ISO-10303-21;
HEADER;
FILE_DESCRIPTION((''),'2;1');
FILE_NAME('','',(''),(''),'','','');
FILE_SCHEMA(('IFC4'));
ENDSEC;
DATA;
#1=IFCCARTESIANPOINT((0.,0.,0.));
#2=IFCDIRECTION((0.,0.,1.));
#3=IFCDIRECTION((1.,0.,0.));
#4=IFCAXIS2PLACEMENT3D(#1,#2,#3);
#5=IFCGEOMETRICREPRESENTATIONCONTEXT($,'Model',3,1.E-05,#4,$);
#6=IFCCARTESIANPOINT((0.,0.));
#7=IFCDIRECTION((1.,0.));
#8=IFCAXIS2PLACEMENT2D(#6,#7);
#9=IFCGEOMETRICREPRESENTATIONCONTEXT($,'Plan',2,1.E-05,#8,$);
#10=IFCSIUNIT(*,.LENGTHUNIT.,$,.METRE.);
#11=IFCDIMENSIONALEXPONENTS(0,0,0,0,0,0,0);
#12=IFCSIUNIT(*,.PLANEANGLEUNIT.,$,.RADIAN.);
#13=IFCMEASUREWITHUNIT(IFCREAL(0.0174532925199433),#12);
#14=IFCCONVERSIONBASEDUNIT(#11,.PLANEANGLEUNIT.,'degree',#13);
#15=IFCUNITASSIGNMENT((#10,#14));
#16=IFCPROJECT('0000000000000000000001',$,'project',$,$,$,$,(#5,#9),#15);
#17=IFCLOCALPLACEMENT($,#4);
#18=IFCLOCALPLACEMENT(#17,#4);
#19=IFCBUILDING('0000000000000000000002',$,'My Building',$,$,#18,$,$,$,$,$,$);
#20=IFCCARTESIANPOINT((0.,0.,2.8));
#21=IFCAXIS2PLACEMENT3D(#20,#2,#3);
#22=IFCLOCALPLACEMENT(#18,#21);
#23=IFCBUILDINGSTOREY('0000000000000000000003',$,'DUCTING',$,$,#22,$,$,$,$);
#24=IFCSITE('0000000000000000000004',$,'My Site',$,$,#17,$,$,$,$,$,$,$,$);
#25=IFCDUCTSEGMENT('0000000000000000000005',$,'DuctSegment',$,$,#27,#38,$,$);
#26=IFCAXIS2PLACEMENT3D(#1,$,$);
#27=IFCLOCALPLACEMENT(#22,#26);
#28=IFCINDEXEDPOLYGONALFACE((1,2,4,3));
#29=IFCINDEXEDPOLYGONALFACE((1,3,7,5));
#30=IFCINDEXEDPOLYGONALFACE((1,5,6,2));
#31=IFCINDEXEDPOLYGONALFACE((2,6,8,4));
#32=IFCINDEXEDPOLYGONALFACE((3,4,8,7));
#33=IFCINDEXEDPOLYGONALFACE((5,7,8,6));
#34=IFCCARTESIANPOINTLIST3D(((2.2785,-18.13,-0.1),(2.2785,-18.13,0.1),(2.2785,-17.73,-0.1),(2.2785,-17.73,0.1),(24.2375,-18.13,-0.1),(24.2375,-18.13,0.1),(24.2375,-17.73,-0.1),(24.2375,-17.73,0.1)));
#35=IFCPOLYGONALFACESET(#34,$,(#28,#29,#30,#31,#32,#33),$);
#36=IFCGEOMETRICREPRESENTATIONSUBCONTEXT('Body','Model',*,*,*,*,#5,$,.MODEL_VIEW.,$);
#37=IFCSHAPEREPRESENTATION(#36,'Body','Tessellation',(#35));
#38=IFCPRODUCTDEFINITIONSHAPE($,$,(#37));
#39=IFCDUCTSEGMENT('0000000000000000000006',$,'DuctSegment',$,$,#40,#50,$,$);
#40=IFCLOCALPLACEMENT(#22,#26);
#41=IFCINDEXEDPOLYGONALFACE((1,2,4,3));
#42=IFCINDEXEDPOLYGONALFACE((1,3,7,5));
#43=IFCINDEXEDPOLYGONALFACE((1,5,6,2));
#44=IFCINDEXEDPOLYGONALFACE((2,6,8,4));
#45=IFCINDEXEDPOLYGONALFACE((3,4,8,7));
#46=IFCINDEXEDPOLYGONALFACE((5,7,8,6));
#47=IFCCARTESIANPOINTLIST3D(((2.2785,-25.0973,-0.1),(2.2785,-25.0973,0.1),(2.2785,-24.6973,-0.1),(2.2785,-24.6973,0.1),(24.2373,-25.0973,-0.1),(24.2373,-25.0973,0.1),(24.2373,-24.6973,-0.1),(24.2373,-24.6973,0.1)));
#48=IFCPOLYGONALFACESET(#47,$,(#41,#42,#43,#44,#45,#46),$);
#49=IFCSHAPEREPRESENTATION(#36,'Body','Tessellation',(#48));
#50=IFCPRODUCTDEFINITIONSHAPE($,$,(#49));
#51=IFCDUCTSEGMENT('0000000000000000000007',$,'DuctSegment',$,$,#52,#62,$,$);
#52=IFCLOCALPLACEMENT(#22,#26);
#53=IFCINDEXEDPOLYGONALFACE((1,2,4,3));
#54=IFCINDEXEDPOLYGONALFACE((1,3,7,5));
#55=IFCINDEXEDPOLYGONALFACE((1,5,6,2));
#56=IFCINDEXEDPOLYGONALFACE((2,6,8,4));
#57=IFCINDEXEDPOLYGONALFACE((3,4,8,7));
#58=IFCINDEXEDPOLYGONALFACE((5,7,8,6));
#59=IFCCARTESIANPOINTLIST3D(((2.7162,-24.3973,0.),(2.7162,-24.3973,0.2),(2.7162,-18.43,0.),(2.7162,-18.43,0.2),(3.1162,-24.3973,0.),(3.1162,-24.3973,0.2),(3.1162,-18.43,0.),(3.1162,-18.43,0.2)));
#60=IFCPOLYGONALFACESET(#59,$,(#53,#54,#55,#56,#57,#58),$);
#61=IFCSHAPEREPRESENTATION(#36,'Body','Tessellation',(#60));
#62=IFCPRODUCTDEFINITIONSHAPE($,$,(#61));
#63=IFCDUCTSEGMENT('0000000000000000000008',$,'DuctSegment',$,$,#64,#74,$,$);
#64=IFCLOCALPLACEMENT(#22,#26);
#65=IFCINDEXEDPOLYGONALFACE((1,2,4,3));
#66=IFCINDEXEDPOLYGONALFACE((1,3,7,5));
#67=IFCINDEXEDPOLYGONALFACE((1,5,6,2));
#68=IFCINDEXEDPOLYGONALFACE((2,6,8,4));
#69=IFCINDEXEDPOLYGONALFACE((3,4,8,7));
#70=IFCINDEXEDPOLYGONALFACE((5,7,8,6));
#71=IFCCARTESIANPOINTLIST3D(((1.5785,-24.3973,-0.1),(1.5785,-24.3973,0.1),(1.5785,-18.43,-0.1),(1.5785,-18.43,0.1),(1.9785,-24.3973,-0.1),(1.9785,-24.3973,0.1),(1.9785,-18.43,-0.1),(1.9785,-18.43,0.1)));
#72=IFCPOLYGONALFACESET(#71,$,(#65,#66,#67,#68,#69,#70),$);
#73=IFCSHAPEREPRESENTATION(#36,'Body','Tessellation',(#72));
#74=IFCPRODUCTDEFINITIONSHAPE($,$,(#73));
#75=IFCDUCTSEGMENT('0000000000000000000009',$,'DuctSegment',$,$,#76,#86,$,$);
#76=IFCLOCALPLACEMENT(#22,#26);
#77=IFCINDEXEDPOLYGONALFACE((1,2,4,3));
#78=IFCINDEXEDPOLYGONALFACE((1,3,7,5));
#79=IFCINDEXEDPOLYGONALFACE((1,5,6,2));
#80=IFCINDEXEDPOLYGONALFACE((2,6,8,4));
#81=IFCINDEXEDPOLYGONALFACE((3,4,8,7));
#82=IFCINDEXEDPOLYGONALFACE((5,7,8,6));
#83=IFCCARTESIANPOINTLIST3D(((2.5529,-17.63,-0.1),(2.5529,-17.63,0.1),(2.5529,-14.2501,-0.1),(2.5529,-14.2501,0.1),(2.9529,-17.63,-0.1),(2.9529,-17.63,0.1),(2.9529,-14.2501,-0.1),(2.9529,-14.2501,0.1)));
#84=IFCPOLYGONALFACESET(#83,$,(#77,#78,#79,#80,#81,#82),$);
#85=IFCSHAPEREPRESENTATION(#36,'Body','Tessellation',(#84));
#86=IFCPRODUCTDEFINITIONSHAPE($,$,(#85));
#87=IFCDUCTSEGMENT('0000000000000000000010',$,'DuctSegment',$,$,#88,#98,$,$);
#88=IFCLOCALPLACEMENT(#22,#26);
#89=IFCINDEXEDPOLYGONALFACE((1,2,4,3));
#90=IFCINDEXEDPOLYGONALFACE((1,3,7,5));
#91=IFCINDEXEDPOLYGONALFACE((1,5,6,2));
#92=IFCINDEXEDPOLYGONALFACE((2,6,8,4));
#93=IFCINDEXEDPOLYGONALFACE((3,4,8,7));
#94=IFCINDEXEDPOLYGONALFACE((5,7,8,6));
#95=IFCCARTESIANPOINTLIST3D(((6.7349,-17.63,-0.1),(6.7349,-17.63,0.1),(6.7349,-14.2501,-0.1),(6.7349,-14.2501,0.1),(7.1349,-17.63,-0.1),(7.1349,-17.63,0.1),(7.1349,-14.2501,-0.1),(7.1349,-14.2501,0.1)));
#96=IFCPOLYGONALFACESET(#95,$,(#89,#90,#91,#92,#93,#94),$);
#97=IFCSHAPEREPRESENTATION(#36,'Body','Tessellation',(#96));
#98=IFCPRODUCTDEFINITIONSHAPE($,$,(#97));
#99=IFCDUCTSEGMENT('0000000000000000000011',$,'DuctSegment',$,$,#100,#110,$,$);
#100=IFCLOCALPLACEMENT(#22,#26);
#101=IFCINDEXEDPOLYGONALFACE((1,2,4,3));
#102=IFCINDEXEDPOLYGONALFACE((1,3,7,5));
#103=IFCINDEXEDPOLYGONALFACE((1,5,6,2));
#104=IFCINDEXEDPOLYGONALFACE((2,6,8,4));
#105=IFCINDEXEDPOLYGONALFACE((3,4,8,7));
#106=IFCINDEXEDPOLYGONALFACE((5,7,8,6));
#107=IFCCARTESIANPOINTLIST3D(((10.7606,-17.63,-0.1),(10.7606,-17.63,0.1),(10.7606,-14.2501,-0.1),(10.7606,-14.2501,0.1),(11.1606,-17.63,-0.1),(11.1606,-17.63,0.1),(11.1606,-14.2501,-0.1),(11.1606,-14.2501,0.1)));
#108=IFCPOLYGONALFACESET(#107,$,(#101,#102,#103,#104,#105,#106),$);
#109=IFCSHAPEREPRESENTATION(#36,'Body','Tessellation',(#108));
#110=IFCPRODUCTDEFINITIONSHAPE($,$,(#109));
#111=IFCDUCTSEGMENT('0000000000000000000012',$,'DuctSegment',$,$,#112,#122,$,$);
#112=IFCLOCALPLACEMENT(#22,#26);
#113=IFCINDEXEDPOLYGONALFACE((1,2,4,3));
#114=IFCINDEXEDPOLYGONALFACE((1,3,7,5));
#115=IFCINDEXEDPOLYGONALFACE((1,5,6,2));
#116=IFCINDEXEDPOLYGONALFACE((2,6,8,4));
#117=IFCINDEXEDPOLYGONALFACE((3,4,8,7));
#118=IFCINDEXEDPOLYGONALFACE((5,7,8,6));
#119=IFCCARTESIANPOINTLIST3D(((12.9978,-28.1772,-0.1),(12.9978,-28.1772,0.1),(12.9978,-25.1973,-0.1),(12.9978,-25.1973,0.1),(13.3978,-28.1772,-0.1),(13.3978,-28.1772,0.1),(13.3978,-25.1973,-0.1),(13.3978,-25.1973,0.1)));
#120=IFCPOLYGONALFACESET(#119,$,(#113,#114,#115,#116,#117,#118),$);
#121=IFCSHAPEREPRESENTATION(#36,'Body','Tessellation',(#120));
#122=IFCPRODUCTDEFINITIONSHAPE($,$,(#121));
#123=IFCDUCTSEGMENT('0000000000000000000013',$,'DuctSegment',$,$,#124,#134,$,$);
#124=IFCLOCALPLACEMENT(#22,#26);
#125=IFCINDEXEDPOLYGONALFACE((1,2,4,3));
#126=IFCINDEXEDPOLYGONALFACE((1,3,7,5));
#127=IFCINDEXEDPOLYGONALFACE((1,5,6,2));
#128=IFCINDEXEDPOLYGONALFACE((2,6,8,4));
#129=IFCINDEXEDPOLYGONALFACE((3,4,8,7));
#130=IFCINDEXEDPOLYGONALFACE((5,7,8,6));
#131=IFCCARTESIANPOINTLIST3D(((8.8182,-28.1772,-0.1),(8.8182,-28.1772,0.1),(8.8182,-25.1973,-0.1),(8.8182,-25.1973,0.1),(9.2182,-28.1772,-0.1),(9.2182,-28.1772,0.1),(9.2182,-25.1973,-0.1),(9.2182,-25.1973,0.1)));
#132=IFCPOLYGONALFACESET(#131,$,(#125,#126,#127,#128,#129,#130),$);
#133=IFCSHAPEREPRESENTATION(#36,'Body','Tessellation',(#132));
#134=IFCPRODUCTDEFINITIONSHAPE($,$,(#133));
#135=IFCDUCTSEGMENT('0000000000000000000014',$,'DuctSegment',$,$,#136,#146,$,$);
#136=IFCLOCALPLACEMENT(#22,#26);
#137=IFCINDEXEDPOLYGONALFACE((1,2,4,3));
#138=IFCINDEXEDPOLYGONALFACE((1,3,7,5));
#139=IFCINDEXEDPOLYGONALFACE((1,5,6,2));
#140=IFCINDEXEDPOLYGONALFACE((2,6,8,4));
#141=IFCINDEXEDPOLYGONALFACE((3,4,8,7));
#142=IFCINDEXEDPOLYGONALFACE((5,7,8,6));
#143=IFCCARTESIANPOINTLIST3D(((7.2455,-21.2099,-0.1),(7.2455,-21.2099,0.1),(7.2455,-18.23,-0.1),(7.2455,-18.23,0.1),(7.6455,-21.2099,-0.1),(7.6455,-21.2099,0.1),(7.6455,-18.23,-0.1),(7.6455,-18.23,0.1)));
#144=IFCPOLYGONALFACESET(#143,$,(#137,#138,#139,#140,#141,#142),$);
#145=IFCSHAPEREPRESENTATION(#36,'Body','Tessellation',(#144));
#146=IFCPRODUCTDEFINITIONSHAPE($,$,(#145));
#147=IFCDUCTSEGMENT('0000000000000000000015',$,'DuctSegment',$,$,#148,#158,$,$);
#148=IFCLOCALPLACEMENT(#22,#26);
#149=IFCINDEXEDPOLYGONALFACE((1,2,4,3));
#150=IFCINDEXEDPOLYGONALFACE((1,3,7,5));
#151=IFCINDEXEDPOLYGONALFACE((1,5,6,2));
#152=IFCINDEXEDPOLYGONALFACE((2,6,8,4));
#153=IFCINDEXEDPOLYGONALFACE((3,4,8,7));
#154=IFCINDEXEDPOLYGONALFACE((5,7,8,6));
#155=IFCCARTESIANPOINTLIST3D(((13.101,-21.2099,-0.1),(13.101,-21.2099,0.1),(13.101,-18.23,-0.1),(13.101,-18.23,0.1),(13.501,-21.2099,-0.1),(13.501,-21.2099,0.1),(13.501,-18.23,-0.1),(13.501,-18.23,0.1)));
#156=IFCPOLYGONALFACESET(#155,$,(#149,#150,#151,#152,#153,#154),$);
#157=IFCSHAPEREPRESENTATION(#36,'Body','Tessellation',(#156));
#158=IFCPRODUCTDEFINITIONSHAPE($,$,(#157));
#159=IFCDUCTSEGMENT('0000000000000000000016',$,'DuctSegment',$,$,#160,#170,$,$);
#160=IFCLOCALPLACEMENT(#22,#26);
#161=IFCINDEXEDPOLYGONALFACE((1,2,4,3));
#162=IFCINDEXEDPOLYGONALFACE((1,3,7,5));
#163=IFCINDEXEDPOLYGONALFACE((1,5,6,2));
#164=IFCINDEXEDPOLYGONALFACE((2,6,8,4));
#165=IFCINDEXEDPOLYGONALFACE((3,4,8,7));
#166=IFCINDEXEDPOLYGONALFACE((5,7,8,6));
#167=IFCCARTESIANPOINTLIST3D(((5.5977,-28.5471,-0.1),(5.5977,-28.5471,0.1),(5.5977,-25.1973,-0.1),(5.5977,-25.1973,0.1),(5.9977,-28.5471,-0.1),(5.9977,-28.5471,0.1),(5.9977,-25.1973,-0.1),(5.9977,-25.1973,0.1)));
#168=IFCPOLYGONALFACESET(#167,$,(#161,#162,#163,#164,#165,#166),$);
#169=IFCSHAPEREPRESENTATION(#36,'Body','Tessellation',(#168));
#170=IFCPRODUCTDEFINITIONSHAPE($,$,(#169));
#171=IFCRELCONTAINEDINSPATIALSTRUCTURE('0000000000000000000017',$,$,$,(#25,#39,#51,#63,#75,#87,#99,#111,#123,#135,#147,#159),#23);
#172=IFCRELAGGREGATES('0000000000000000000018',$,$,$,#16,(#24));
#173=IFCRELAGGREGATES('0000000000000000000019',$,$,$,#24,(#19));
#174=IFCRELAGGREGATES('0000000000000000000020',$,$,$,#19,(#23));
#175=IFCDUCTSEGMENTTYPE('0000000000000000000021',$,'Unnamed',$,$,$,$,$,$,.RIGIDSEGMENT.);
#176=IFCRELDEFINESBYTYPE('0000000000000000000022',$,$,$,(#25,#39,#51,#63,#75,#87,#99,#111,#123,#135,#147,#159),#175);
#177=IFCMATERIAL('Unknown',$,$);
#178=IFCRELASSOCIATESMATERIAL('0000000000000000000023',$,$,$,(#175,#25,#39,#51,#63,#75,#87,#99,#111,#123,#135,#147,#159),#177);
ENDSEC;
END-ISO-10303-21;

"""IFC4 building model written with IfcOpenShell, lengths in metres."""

from ifc_helpers import new_model, entity, si_unit, converted_unit, frame, origin_with_axes, origin_2d_with_axis, place, context, subcontext, project, spatial, rectangle, extrude, material, material_profile, profile_set, profile_usage, type_object, element, save


model = new_model("IFC4")

# Units and contexts
model_context = context("Model", 3, precision=1e-05, world=origin_with_axes())
plan_context = context("Plan", 2, precision=1e-05, world=origin_2d_with_axis())
body_context = subcontext(model_context, "Body", "Model", "MODEL_VIEW")
ifc_project = project(units=[si_unit("LENGTHUNIT", "METRE"), converted_unit("PLANEANGLEUNIT", "degree", entity("IfcReal", 0.0174532925199433), si_unit("PLANEANGLEUNIT", "RADIAN"), dimensions=[0, 0, 0, 0, 0, 0, 0])], contexts=[model_context, plan_context])

# Site, building, storey
site_placement = place(None, origin_with_axes())
site = spatial("IfcSite", under=ifc_project, at=site_placement, Name="My Site")
building_placement = place(site_placement, origin_with_axes())
building = spatial("IfcBuilding", under=site, at=building_placement, Name="My Building")
storey_placement = place(building_placement, frame((0.0, 0.0, 2.8), z_axis=(0.0, 0.0, 1.0), x_axis=(1.0, 0.0, 0.0)))
storey = spatial("IfcBuildingStorey", under=building, at=storey_placement, Name="DUCTING")

# Duct segments
ifc_material = material(Name="Unknown")
ifc_material_profile_1 = material_profile(ifc_material, rectangle(XDim=0.4, YDim=0.2))
ifc_profile_set_1 = profile_set([ifc_material_profile_1])
ifc_profile_usage_1 = profile_usage(ifc_profile_set_1, cardinal=5)
duct_segment_type = type_object("IfcDuctSegmentType", Name="Unnamed", PredefinedType="RIGIDSEGMENT", material=ifc_profile_set_1)
duct_segment_1_placement = place(storey_placement, frame((2.2785, -17.93, 0.0), z_axis=(1.0, 0.0, 0.0), x_axis=(0.0, 1.0, 0.0)))
element("IfcDuctSegment", 1, at=duct_segment_1_placement, inside=storey, type_object=duct_segment_type, material=ifc_profile_usage_1, Name="DuctSegment", context=body_context, shape_type="SweptSolid", body=[
    extrude(rectangle(XDim=0.4, YDim=0.2), origin_with_axes(), (0.0, 0.0, 1.0), 21.959),
])
ifc_profile_usage_2 = profile_usage(ifc_profile_set_1, cardinal=5)
duct_segment_2_placement = place(storey_placement, frame((2.2785, -24.8973, 0.0), z_axis=(1.0, 0.0, 0.0), x_axis=(0.0, 1.0, 0.0)))
element("IfcDuctSegment", 2, at=duct_segment_2_placement, inside=storey, type_object=duct_segment_type, material=ifc_profile_usage_2, Name="DuctSegment", context=body_context, shape_type="SweptSolid", body=[
    extrude(rectangle(XDim=0.4, YDim=0.2), origin_with_axes(), (0.0, 0.0, 1.0), 21.9588),
])
ifc_profile_usage_3 = profile_usage(ifc_profile_set_1, cardinal=5)
duct_segment_3_placement = place(storey_placement, frame((2.9162, -18.43, 0.1), z_axis=(0.0, -1.0, 0.0), x_axis=(1.0, 0.0, 0.0)))
element("IfcDuctSegment", 3, at=duct_segment_3_placement, inside=storey, type_object=duct_segment_type, material=ifc_profile_usage_3, Name="DuctSegment", context=body_context, shape_type="SweptSolid", body=[
    extrude(rectangle(XDim=0.4, YDim=0.2), origin_with_axes(), (0.0, 0.0, 1.0), 5.9673),
])
ifc_profile_usage_4 = profile_usage(ifc_profile_set_1, cardinal=5)
duct_segment_4_placement = place(storey_placement, frame((1.7785, -18.43, 0.0), z_axis=(0.0, -1.0, 0.0), x_axis=(1.0, 0.0, 0.0)))
element("IfcDuctSegment", 4, at=duct_segment_4_placement, inside=storey, type_object=duct_segment_type, material=ifc_profile_usage_4, Name="DuctSegment", context=body_context, shape_type="SweptSolid", body=[
    extrude(rectangle(XDim=0.4, YDim=0.2), origin_with_axes(), (0.0, 0.0, 1.0), 5.9673),
])
ifc_profile_usage_5 = profile_usage(ifc_profile_set_1, cardinal=5)
duct_segment_5_placement = place(storey_placement, frame((2.7529, -17.63, 0.0), z_axis=(0.0, 1.0, 0.0), x_axis=(-1.0, 0.0, 0.0)))
element("IfcDuctSegment", 5, at=duct_segment_5_placement, inside=storey, type_object=duct_segment_type, material=ifc_profile_usage_5, Name="DuctSegment", context=body_context, shape_type="SweptSolid", body=[
    extrude(rectangle(XDim=0.4, YDim=0.2), origin_with_axes(), (0.0, 0.0, 1.0), 3.3799),
])
ifc_profile_usage_6 = profile_usage(ifc_profile_set_1, cardinal=5)
duct_segment_6_placement = place(storey_placement, frame((6.9349, -17.63, 0.0), z_axis=(0.0, 1.0, 0.0), x_axis=(-1.0, 0.0, 0.0)))
element("IfcDuctSegment", 6, at=duct_segment_6_placement, inside=storey, type_object=duct_segment_type, material=ifc_profile_usage_6, Name="DuctSegment", context=body_context, shape_type="SweptSolid", body=[
    extrude(rectangle(XDim=0.4, YDim=0.2), origin_with_axes(), (0.0, 0.0, 1.0), 3.3799),
])
ifc_profile_usage_7 = profile_usage(ifc_profile_set_1, cardinal=5)
duct_segment_7_placement = place(storey_placement, frame((10.9606, -17.63, 0.0), z_axis=(0.0, 1.0, 0.0), x_axis=(-1.0, 0.0, 0.0)))
element("IfcDuctSegment", 7, at=duct_segment_7_placement, inside=storey, type_object=duct_segment_type, material=ifc_profile_usage_7, Name="DuctSegment", context=body_context, shape_type="SweptSolid", body=[
    extrude(rectangle(XDim=0.4, YDim=0.2), origin_with_axes(), (0.0, 0.0, 1.0), 3.3799),
])
ifc_profile_usage_8 = profile_usage(ifc_profile_set_1, cardinal=5)
duct_segment_8_placement = place(storey_placement, frame((13.1978, -25.1973, 0.0), z_axis=(0.0, -1.0, 0.0), x_axis=(1.0, 0.0, 0.0)))
element("IfcDuctSegment", 8, at=duct_segment_8_placement, inside=storey, type_object=duct_segment_type, material=ifc_profile_usage_8, Name="DuctSegment", context=body_context, shape_type="SweptSolid", body=[
    extrude(rectangle(XDim=0.4, YDim=0.2), origin_with_axes(), (0.0, 0.0, 1.0), 2.9799),
])
ifc_profile_usage_9 = profile_usage(ifc_profile_set_1, cardinal=5)
duct_segment_9_placement = place(storey_placement, frame((9.0182, -25.1973, 0.0), z_axis=(0.0, -1.0, 0.0), x_axis=(1.0, 0.0, 0.0)))
element("IfcDuctSegment", 9, at=duct_segment_9_placement, inside=storey, type_object=duct_segment_type, material=ifc_profile_usage_9, Name="DuctSegment", context=body_context, shape_type="SweptSolid", body=[
    extrude(rectangle(XDim=0.4, YDim=0.2), origin_with_axes(), (0.0, 0.0, 1.0), 2.9799),
])
ifc_profile_usage_10 = profile_usage(ifc_profile_set_1, cardinal=5)
duct_segment_10_placement = place(storey_placement, frame((7.4455, -18.23, 0.0), z_axis=(0.0, -1.0, 0.0), x_axis=(1.0, 0.0, 0.0)))
element("IfcDuctSegment", 10, at=duct_segment_10_placement, inside=storey, type_object=duct_segment_type, material=ifc_profile_usage_10, Name="DuctSegment", context=body_context, shape_type="SweptSolid", body=[
    extrude(rectangle(XDim=0.4, YDim=0.2), origin_with_axes(), (0.0, 0.0, 1.0), 2.9799),
])
ifc_profile_usage_11 = profile_usage(ifc_profile_set_1, cardinal=5)
duct_segment_11_placement = place(storey_placement, frame((13.301, -18.23, 0.0), z_axis=(0.0, -1.0, 0.0), x_axis=(1.0, 0.0, 0.0)))
element("IfcDuctSegment", 11, at=duct_segment_11_placement, inside=storey, type_object=duct_segment_type, material=ifc_profile_usage_11, Name="DuctSegment", context=body_context, shape_type="SweptSolid", body=[
    extrude(rectangle(XDim=0.4, YDim=0.2), origin_with_axes(), (0.0, 0.0, 1.0), 2.9799),
])
ifc_profile_usage_12 = profile_usage(ifc_profile_set_1, cardinal=5)
duct_segment_12_placement = place(storey_placement, frame((5.7977, -25.1973, 0.0), z_axis=(0.0, -1.0, 0.0), x_axis=(1.0, 0.0, 0.0)))
element("IfcDuctSegment", 12, at=duct_segment_12_placement, inside=storey, type_object=duct_segment_type, material=ifc_profile_usage_12, Name="DuctSegment", context=body_context, shape_type="SweptSolid", body=[
    extrude(rectangle(XDim=0.4, YDim=0.2), origin_with_axes(), (0.0, 0.0, 1.0), 3.3498),
])

save(model, "model.ifc")
